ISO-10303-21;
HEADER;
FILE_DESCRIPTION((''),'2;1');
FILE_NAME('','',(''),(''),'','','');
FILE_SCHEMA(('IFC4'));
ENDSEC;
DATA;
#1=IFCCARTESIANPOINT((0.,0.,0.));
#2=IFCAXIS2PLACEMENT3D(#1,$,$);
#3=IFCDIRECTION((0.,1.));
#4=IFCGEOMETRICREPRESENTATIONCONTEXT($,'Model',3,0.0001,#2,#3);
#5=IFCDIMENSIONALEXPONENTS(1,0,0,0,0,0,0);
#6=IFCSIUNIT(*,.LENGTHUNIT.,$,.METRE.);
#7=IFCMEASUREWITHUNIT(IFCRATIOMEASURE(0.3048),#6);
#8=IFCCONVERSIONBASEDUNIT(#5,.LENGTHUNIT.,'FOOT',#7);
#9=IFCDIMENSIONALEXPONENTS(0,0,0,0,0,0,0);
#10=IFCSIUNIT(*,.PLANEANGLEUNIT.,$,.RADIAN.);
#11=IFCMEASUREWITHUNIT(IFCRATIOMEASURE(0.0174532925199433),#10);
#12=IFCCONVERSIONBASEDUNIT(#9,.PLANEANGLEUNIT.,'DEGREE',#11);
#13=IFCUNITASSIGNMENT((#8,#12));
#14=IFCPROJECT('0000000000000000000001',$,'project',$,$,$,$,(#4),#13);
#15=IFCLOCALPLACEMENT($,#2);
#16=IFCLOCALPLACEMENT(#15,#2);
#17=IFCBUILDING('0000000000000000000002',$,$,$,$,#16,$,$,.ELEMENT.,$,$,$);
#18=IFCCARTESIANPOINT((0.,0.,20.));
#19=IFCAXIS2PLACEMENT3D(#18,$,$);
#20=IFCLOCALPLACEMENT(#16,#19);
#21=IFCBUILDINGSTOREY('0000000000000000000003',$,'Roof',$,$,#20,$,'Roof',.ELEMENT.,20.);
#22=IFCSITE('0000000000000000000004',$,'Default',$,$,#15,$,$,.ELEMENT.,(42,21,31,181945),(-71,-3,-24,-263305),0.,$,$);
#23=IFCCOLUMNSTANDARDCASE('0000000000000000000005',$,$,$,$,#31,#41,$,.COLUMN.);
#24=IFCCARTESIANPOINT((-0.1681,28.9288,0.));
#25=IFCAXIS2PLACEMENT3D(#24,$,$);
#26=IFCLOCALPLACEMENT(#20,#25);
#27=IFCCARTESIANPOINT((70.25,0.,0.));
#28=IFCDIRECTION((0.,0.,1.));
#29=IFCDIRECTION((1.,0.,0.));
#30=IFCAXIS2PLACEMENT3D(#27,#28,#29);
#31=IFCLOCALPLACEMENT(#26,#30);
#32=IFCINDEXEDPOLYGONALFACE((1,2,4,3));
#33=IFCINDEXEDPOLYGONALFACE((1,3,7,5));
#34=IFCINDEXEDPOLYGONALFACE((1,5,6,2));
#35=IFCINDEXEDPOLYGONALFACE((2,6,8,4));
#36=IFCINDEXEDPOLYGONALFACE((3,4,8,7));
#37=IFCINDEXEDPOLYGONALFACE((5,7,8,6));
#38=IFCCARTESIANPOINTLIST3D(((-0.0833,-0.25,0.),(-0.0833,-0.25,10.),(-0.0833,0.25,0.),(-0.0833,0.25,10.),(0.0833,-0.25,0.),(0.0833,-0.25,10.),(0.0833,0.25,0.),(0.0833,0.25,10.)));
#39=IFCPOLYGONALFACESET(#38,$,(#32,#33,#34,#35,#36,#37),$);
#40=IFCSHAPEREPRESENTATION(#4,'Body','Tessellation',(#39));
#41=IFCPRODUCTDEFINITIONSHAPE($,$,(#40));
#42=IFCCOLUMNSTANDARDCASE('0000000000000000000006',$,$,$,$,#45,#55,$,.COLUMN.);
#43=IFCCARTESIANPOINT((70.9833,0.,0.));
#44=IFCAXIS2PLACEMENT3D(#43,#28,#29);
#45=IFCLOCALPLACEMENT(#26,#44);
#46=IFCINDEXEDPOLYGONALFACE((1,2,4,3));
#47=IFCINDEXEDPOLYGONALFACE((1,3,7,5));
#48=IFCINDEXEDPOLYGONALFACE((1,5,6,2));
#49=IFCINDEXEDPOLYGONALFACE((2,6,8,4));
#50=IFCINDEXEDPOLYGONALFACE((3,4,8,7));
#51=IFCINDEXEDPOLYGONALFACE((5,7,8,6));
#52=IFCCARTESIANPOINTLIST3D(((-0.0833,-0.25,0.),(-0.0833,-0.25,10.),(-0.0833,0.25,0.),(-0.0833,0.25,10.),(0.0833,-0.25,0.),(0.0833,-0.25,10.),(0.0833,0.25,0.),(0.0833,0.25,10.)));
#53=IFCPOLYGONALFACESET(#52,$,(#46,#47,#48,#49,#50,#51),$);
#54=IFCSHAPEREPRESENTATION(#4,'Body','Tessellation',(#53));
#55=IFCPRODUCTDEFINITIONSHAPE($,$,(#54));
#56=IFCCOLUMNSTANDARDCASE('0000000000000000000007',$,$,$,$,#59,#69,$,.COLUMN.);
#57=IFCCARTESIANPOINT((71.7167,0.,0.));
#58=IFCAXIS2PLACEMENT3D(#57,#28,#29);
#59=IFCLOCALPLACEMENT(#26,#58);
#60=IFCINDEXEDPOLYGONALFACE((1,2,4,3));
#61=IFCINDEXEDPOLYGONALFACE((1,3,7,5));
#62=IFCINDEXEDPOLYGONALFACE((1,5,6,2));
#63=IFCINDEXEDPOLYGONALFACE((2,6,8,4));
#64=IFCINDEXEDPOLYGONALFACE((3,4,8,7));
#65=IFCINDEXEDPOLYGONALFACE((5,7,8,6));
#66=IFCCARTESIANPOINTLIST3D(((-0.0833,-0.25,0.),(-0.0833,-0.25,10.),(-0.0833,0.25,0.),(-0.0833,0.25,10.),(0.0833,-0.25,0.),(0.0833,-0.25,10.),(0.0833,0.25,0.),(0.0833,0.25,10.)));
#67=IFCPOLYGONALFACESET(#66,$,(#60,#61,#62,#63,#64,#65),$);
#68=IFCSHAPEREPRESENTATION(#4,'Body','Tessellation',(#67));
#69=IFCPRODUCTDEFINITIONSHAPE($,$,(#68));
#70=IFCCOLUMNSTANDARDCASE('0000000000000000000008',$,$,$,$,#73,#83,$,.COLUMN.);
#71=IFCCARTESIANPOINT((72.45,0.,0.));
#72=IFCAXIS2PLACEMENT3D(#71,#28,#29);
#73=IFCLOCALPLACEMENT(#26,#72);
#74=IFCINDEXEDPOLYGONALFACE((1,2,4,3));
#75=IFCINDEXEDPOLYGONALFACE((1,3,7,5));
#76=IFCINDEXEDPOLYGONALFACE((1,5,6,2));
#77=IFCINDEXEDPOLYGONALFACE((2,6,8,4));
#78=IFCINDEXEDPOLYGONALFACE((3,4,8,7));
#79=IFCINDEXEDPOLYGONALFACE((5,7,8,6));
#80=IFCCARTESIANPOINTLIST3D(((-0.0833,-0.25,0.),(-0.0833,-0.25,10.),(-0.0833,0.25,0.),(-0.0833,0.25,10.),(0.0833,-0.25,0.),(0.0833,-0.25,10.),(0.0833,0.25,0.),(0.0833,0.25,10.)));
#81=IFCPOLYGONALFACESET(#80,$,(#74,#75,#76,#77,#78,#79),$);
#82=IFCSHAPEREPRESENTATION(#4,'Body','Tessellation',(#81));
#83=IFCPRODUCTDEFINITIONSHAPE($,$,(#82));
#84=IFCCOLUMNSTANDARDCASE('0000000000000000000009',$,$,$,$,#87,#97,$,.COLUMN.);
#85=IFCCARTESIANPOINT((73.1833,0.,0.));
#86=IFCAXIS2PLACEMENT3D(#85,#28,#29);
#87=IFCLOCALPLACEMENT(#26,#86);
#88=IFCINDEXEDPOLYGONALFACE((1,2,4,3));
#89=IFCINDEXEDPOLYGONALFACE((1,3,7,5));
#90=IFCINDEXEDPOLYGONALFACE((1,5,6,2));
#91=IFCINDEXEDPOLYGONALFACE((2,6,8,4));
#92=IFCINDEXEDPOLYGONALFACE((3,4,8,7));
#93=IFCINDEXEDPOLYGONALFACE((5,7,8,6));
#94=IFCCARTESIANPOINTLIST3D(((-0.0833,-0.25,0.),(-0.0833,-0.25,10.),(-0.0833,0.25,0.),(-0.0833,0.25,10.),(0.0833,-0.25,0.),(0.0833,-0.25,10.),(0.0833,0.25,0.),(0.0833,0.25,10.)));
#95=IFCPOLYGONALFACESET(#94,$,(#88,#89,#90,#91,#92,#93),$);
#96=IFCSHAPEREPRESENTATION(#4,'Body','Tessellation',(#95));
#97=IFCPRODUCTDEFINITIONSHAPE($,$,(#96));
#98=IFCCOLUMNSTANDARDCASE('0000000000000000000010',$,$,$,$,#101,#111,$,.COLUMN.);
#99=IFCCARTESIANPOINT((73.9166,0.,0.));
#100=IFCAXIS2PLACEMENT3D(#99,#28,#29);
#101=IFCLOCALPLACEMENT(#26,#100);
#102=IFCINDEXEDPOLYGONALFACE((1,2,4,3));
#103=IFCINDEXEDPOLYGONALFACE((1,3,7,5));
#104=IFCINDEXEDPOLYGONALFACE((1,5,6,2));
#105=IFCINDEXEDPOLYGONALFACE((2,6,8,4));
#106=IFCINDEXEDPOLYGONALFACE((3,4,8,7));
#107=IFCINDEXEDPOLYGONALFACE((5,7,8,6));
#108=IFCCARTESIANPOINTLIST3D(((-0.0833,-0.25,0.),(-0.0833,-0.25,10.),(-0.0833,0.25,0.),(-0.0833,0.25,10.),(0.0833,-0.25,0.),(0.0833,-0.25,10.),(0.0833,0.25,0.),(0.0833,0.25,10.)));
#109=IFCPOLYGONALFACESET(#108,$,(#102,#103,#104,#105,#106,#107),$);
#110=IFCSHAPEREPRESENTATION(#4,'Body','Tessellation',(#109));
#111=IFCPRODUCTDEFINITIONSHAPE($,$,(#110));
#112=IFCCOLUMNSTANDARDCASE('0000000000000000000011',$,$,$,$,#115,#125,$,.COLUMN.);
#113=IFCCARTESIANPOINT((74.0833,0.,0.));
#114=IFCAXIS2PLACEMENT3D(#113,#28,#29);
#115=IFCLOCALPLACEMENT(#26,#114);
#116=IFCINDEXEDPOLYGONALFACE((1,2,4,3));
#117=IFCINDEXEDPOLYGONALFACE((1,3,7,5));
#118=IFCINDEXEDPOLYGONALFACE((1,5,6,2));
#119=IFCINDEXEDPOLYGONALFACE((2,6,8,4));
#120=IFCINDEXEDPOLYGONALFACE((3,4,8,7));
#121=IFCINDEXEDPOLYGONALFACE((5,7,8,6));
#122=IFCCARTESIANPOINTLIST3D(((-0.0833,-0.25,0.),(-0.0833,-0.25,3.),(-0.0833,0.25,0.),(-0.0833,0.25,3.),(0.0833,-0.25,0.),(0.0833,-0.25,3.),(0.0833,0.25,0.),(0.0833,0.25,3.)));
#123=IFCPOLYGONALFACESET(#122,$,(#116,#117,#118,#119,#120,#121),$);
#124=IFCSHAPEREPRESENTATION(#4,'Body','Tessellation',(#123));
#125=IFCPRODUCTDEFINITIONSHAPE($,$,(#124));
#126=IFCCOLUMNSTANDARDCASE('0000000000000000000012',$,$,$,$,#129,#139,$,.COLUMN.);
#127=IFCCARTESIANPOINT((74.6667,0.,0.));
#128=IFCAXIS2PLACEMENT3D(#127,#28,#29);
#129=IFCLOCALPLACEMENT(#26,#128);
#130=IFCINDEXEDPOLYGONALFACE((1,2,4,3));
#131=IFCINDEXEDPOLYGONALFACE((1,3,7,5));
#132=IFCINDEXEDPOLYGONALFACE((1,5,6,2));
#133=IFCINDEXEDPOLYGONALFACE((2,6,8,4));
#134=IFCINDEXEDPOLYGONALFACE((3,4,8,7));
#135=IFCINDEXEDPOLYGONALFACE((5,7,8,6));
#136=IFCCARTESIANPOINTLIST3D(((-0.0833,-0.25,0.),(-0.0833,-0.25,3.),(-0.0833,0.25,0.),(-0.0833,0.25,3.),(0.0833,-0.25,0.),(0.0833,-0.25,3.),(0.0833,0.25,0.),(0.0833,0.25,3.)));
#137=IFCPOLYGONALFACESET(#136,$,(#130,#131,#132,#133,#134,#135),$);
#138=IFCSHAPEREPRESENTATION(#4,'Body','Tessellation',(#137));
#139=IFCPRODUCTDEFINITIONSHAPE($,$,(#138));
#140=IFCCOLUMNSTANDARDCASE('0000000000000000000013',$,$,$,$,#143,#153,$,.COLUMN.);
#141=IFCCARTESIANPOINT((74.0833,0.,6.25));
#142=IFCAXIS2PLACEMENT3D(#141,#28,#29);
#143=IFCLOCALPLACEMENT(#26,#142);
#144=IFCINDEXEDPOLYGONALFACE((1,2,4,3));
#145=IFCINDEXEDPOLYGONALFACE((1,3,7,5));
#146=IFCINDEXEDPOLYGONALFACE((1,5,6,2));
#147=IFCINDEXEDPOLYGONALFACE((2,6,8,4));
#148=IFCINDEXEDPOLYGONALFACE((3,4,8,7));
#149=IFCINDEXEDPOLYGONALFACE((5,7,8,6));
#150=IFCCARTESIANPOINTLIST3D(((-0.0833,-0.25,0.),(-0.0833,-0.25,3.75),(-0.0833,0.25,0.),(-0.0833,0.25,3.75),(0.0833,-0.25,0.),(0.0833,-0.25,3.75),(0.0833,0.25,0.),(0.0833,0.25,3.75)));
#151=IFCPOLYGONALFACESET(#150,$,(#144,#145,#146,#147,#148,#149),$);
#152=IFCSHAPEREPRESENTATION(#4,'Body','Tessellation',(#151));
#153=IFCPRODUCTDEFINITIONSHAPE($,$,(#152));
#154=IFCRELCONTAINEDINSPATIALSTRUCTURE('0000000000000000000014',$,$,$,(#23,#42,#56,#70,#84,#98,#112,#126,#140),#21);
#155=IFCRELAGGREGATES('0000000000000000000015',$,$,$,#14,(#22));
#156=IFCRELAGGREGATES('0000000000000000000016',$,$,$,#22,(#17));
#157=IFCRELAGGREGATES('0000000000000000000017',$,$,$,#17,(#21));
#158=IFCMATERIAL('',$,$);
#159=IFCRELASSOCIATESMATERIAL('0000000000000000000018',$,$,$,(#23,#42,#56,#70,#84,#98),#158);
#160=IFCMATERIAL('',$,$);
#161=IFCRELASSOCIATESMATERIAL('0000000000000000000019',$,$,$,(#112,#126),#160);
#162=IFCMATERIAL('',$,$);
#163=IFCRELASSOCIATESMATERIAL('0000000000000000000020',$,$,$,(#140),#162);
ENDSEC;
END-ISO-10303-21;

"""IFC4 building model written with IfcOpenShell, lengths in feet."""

from ifc_helpers import new_model, entity, si_unit, converted_unit, direction, frame, origin, place, context, project, spatial, rectangle, extrude, material, element, save


model = new_model("IFC4")

# Units and contexts
model_context = context("Model", 3, precision=0.0001, world=origin(), true_north=direction((0.0, 1.0)))
ifc_project = project(units=[converted_unit("LENGTHUNIT", "FOOT", entity("IfcRatioMeasure", 0.3048), si_unit("LENGTHUNIT", "METRE"), dimensions=[1, 0, 0, 0, 0, 0, 0]), converted_unit("PLANEANGLEUNIT", "DEGREE", entity("IfcRatioMeasure", 0.0174532925199433), si_unit("PLANEANGLEUNIT", "RADIAN"), dimensions=[0, 0, 0, 0, 0, 0, 0])], contexts=[model_context])

# Site, building, storey
site_placement = place(None, origin())
site = spatial("IfcSite", under=ifc_project, at=site_placement, Name="Default", CompositionType="ELEMENT", RefLatitude=(42, 21, 31, 181945), RefLongitude=(-71, -3, -24, -263305), RefElevation=0.0)
building_placement = place(site_placement, origin())
building = spatial("IfcBuilding", under=site, at=building_placement, CompositionType="ELEMENT")
storey_placement = place(building_placement, frame((0.0, 0.0, 20.0)))
storey = spatial("IfcBuildingStorey", under=building, at=storey_placement, Name="Roof", LongName="Roof", CompositionType="ELEMENT", Elevation=20.0)

# Columns
ifc_material_1 = material(Name="")
placement = place(storey_placement, frame((-0.1681, 28.9288, 0.0)))
for number, where, z_axis, x_axis in (
    (1, (70.25, 0.0, 0.0), (0.0, 0.0, 1.0), (1.0, 0.0, 0.0)),
    (2, (70.9833, 0.0, 0.0), (0.0, 0.0, 1.0), (1.0, 0.0, 0.0)),
    (3, (71.7167, 0.0, 0.0), (0.0, 0.0, 1.0), (1.0, 0.0, 0.0)),
    (4, (72.45, 0.0, 0.0), (0.0, 0.0, 1.0), (1.0, 0.0, 0.0)),
    (5, (73.1833, 0.0, 0.0), (0.0, 0.0, 1.0), (1.0, 0.0, 0.0)),
    (6, (73.9166, 0.0, 0.0), (0.0, 0.0, 1.0), (1.0, 0.0, 0.0)),
):
    element("IfcColumnStandardCase", number, at=place(placement, frame(where, z_axis=z_axis, x_axis=x_axis)), inside=storey, material=ifc_material_1, PredefinedType="COLUMN", context=model_context, shape_type="SweptSolid", body=[
        extrude(rectangle(XDim=0.1667, YDim=0.5), origin(), (0.0, 0.0, 1.0), 10.0),
    ])
ifc_material_2 = material(Name="")
for number, where, z_axis, x_axis in (
    (7, (74.0833, 0.0, 0.0), (0.0, 0.0, 1.0), (1.0, 0.0, 0.0)),
    (8, (74.6667, 0.0, 0.0), (0.0, 0.0, 1.0), (1.0, 0.0, 0.0)),
):
    element("IfcColumnStandardCase", number, at=place(placement, frame(where, z_axis=z_axis, x_axis=x_axis)), inside=storey, material=ifc_material_2, PredefinedType="COLUMN", context=model_context, shape_type="SweptSolid", body=[
        extrude(rectangle(XDim=0.1667, YDim=0.5), origin(), (0.0, 0.0, 1.0), 3.0),
    ])
ifc_material_3 = material(Name="")
for number, where, z_axis, x_axis in (
    (9, (74.0833, 0.0, 6.25), (0.0, 0.0, 1.0), (1.0, 0.0, 0.0)),
):
    element("IfcColumnStandardCase", number, at=place(placement, frame(where, z_axis=z_axis, x_axis=x_axis)), inside=storey, material=ifc_material_3, PredefinedType="COLUMN", context=model_context, shape_type="SweptSolid", body=[
        extrude(rectangle(XDim=0.1667, YDim=0.5), origin(), (0.0, 0.0, 1.0), 3.75),
    ])

save(model, "model.ifc")
